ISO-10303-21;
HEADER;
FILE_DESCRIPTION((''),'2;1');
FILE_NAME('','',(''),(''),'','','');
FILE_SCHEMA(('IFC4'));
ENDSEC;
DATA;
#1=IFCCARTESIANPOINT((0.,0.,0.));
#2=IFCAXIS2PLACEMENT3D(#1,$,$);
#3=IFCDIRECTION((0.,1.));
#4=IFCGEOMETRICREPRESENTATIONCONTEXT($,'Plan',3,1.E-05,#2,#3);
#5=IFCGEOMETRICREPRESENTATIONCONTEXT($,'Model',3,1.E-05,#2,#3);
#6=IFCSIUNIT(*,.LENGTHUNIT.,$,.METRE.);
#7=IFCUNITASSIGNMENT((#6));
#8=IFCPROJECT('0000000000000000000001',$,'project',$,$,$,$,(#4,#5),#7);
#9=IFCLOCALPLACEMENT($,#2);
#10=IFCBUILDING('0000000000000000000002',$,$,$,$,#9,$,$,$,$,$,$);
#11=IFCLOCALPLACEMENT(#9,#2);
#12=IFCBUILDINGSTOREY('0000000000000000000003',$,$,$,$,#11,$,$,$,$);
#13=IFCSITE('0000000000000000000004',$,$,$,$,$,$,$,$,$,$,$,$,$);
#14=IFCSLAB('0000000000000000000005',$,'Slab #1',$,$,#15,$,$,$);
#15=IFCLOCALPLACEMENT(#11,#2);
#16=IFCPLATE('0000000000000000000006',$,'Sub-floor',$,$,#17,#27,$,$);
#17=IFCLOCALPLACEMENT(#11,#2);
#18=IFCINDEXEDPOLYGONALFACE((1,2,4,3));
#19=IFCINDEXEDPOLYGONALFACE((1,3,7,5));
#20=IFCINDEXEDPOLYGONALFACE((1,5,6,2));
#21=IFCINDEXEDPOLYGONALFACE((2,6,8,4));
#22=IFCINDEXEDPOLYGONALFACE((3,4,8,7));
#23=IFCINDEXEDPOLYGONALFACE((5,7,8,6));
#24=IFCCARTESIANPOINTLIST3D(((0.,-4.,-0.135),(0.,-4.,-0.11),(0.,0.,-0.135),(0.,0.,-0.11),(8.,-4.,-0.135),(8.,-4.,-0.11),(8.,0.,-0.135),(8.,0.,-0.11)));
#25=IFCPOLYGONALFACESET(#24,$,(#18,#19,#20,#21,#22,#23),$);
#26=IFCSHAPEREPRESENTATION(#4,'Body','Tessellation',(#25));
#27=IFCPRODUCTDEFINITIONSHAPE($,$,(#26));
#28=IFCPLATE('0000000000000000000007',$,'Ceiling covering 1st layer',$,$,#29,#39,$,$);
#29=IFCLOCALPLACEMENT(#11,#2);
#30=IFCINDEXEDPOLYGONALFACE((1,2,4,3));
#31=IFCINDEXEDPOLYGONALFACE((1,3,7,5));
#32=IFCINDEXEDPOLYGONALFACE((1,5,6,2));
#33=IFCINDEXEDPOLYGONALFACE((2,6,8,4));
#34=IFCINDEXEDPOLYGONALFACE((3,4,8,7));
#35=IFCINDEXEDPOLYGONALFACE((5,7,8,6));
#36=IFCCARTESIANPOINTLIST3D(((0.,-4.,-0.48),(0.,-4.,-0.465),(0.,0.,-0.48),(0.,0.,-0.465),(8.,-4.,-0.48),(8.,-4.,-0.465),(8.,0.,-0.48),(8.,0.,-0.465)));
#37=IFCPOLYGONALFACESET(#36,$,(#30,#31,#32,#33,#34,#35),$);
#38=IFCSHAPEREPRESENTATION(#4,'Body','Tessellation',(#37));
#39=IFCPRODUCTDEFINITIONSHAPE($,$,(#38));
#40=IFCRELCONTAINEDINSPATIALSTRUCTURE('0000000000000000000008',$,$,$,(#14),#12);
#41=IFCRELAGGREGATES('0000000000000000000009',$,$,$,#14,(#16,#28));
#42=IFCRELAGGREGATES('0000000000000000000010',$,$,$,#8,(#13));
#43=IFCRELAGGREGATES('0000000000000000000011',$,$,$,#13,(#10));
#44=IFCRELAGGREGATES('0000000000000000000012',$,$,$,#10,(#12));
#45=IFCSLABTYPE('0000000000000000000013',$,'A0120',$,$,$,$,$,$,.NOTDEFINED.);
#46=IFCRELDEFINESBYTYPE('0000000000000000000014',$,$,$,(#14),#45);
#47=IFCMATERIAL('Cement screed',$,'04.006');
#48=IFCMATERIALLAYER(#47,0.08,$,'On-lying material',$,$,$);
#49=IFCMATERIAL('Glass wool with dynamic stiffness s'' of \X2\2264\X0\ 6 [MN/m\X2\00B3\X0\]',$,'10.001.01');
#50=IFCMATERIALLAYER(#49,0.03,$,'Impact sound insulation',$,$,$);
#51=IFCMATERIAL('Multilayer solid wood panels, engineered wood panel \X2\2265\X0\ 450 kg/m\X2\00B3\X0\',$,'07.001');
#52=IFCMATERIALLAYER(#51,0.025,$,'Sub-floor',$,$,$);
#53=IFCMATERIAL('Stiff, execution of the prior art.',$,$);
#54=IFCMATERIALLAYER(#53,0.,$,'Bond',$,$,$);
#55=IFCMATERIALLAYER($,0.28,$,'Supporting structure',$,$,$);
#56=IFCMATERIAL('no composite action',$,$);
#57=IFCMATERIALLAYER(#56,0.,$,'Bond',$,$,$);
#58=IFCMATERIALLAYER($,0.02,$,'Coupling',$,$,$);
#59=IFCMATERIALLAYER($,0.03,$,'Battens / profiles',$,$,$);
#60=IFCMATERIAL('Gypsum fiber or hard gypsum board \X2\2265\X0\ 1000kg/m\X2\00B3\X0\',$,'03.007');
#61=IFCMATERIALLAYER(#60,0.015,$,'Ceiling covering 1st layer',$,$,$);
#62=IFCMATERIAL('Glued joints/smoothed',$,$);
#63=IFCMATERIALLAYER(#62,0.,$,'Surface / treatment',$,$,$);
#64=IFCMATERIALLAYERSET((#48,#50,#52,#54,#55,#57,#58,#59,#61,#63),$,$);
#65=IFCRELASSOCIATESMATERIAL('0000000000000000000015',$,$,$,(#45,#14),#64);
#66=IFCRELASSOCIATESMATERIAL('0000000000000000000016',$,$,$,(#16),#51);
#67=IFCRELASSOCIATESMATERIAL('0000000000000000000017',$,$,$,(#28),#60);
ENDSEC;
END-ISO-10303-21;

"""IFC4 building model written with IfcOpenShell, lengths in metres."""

from ifc_helpers import new_model, si_unit, direction, frame, frame_2d, origin, place, context, project, spatial, rectangle, extrude, material, layer, layer_set, type_object, element, aggregate, save


model = new_model("IFC4")

# Units and contexts
plan_context = context("Plan", 3, precision=1e-05, world=origin(), true_north=direction((0.0, 1.0)))
model_context = context("Model", 3, precision=1e-05, world=origin(), true_north=direction((0.0, 1.0)))
ifc_project = project(units=[si_unit("LENGTHUNIT", "METRE")], contexts=[plan_context, model_context])

# Site, building, storey
site = spatial("IfcSite", under=ifc_project)
building_placement = place(None, origin())
building = spatial("IfcBuilding", under=site, at=building_placement)
storey_placement = place(building_placement, origin())
storey = spatial("IfcBuildingStorey", under=building, at=storey_placement)

# Slab, plates
ifc_material_1 = material(Name="Cement screed", Category="04.006")
ifc_layer_1 = layer(ifc_material_1, 0.08, Name="On-lying material")
ifc_material_2 = material(Name="Glass wool with dynamic stiffness s' of ≤ 6 [MN/m³]", Category="10.001.01")
ifc_layer_2 = layer(ifc_material_2, 0.03, Name="Impact sound insulation")
ifc_material_3 = material(Name="Multilayer solid wood panels, engineered wood panel ≥ 450 kg/m³", Category="07.001")
ifc_layer_3 = layer(ifc_material_3, 0.025, Name="Sub-floor")
ifc_material_4 = material(Name="Stiff, execution of the prior art.")
ifc_layer_4 = layer(ifc_material_4, 0.0, Name="Bond")
ifc_layer_5 = layer(None, 0.28, Name="Supporting structure")
ifc_material_5 = material(Name="no composite action")
ifc_layer_6 = layer(ifc_material_5, 0.0, Name="Bond")
ifc_layer_7 = layer(None, 0.02, Name="Coupling")
ifc_layer_8 = layer(None, 0.03, Name="Battens / profiles")
ifc_material_6 = material(Name="Gypsum fiber or hard gypsum board ≥ 1000kg/m³", Category="03.007")
ifc_layer_9 = layer(ifc_material_6, 0.015, Name="Ceiling covering 1st layer")
ifc_material_7 = material(Name="Glued joints/smoothed")
ifc_layer_10 = layer(ifc_material_7, 0.0, Name="Surface / treatment")
ifc_layer_set = layer_set([ifc_layer_1, ifc_layer_2, ifc_layer_3, ifc_layer_4, ifc_layer_5, ifc_layer_6, ifc_layer_7, ifc_layer_8, ifc_layer_9, ifc_layer_10])
slab_type = type_object("IfcSlabType", Name="A0120", PredefinedType="NOTDEFINED", material=ifc_layer_set)
slab_placement = place(None, frame((0.0, 0.0, 0.0), z_axis=(0.0, 0.0, -1.0), x_axis=(1.0, 0.0, 0.0)))
slab = element("IfcSlab", 1, at=slab_placement, inside=storey, type_object=slab_type, material=ifc_layer_set, Name="Slab #1")
plate_1_placement = place(slab_placement, origin())
plate_1 = element("IfcPlate", 2, at=plate_1_placement, material=ifc_material_3, Name="Sub-floor", context=plan_context, shape_type="SweptSolid", body=[
    extrude(rectangle(XDim=8.0, YDim=4.0, at=frame_2d((4.0, 2.0), x_axis=(1.0, 0.0))), frame((0.0, 0.0, 0.11), z_axis=(0.0, 0.0, 1.0), x_axis=(1.0, 0.0, 0.0)), (0.0, 0.0, 1.0), 0.025),
])
plate_2_placement = place(slab_placement, origin())
plate_2 = element("IfcPlate", 3, at=plate_2_placement, material=ifc_material_6, Name="Ceiling covering 1st layer", context=plan_context, shape_type="SweptSolid", body=[
    extrude(rectangle(XDim=8.0, YDim=4.0, at=frame_2d((4.0, 2.0), x_axis=(1.0, 0.0))), frame((0.0, 0.0, 0.465), z_axis=(0.0, 0.0, 1.0), x_axis=(1.0, 0.0, 0.0)), (0.0, 0.0, 1.0), 0.015),
])
aggregate(slab, [plate_1, plate_2])

save(model, "model.ifc")
